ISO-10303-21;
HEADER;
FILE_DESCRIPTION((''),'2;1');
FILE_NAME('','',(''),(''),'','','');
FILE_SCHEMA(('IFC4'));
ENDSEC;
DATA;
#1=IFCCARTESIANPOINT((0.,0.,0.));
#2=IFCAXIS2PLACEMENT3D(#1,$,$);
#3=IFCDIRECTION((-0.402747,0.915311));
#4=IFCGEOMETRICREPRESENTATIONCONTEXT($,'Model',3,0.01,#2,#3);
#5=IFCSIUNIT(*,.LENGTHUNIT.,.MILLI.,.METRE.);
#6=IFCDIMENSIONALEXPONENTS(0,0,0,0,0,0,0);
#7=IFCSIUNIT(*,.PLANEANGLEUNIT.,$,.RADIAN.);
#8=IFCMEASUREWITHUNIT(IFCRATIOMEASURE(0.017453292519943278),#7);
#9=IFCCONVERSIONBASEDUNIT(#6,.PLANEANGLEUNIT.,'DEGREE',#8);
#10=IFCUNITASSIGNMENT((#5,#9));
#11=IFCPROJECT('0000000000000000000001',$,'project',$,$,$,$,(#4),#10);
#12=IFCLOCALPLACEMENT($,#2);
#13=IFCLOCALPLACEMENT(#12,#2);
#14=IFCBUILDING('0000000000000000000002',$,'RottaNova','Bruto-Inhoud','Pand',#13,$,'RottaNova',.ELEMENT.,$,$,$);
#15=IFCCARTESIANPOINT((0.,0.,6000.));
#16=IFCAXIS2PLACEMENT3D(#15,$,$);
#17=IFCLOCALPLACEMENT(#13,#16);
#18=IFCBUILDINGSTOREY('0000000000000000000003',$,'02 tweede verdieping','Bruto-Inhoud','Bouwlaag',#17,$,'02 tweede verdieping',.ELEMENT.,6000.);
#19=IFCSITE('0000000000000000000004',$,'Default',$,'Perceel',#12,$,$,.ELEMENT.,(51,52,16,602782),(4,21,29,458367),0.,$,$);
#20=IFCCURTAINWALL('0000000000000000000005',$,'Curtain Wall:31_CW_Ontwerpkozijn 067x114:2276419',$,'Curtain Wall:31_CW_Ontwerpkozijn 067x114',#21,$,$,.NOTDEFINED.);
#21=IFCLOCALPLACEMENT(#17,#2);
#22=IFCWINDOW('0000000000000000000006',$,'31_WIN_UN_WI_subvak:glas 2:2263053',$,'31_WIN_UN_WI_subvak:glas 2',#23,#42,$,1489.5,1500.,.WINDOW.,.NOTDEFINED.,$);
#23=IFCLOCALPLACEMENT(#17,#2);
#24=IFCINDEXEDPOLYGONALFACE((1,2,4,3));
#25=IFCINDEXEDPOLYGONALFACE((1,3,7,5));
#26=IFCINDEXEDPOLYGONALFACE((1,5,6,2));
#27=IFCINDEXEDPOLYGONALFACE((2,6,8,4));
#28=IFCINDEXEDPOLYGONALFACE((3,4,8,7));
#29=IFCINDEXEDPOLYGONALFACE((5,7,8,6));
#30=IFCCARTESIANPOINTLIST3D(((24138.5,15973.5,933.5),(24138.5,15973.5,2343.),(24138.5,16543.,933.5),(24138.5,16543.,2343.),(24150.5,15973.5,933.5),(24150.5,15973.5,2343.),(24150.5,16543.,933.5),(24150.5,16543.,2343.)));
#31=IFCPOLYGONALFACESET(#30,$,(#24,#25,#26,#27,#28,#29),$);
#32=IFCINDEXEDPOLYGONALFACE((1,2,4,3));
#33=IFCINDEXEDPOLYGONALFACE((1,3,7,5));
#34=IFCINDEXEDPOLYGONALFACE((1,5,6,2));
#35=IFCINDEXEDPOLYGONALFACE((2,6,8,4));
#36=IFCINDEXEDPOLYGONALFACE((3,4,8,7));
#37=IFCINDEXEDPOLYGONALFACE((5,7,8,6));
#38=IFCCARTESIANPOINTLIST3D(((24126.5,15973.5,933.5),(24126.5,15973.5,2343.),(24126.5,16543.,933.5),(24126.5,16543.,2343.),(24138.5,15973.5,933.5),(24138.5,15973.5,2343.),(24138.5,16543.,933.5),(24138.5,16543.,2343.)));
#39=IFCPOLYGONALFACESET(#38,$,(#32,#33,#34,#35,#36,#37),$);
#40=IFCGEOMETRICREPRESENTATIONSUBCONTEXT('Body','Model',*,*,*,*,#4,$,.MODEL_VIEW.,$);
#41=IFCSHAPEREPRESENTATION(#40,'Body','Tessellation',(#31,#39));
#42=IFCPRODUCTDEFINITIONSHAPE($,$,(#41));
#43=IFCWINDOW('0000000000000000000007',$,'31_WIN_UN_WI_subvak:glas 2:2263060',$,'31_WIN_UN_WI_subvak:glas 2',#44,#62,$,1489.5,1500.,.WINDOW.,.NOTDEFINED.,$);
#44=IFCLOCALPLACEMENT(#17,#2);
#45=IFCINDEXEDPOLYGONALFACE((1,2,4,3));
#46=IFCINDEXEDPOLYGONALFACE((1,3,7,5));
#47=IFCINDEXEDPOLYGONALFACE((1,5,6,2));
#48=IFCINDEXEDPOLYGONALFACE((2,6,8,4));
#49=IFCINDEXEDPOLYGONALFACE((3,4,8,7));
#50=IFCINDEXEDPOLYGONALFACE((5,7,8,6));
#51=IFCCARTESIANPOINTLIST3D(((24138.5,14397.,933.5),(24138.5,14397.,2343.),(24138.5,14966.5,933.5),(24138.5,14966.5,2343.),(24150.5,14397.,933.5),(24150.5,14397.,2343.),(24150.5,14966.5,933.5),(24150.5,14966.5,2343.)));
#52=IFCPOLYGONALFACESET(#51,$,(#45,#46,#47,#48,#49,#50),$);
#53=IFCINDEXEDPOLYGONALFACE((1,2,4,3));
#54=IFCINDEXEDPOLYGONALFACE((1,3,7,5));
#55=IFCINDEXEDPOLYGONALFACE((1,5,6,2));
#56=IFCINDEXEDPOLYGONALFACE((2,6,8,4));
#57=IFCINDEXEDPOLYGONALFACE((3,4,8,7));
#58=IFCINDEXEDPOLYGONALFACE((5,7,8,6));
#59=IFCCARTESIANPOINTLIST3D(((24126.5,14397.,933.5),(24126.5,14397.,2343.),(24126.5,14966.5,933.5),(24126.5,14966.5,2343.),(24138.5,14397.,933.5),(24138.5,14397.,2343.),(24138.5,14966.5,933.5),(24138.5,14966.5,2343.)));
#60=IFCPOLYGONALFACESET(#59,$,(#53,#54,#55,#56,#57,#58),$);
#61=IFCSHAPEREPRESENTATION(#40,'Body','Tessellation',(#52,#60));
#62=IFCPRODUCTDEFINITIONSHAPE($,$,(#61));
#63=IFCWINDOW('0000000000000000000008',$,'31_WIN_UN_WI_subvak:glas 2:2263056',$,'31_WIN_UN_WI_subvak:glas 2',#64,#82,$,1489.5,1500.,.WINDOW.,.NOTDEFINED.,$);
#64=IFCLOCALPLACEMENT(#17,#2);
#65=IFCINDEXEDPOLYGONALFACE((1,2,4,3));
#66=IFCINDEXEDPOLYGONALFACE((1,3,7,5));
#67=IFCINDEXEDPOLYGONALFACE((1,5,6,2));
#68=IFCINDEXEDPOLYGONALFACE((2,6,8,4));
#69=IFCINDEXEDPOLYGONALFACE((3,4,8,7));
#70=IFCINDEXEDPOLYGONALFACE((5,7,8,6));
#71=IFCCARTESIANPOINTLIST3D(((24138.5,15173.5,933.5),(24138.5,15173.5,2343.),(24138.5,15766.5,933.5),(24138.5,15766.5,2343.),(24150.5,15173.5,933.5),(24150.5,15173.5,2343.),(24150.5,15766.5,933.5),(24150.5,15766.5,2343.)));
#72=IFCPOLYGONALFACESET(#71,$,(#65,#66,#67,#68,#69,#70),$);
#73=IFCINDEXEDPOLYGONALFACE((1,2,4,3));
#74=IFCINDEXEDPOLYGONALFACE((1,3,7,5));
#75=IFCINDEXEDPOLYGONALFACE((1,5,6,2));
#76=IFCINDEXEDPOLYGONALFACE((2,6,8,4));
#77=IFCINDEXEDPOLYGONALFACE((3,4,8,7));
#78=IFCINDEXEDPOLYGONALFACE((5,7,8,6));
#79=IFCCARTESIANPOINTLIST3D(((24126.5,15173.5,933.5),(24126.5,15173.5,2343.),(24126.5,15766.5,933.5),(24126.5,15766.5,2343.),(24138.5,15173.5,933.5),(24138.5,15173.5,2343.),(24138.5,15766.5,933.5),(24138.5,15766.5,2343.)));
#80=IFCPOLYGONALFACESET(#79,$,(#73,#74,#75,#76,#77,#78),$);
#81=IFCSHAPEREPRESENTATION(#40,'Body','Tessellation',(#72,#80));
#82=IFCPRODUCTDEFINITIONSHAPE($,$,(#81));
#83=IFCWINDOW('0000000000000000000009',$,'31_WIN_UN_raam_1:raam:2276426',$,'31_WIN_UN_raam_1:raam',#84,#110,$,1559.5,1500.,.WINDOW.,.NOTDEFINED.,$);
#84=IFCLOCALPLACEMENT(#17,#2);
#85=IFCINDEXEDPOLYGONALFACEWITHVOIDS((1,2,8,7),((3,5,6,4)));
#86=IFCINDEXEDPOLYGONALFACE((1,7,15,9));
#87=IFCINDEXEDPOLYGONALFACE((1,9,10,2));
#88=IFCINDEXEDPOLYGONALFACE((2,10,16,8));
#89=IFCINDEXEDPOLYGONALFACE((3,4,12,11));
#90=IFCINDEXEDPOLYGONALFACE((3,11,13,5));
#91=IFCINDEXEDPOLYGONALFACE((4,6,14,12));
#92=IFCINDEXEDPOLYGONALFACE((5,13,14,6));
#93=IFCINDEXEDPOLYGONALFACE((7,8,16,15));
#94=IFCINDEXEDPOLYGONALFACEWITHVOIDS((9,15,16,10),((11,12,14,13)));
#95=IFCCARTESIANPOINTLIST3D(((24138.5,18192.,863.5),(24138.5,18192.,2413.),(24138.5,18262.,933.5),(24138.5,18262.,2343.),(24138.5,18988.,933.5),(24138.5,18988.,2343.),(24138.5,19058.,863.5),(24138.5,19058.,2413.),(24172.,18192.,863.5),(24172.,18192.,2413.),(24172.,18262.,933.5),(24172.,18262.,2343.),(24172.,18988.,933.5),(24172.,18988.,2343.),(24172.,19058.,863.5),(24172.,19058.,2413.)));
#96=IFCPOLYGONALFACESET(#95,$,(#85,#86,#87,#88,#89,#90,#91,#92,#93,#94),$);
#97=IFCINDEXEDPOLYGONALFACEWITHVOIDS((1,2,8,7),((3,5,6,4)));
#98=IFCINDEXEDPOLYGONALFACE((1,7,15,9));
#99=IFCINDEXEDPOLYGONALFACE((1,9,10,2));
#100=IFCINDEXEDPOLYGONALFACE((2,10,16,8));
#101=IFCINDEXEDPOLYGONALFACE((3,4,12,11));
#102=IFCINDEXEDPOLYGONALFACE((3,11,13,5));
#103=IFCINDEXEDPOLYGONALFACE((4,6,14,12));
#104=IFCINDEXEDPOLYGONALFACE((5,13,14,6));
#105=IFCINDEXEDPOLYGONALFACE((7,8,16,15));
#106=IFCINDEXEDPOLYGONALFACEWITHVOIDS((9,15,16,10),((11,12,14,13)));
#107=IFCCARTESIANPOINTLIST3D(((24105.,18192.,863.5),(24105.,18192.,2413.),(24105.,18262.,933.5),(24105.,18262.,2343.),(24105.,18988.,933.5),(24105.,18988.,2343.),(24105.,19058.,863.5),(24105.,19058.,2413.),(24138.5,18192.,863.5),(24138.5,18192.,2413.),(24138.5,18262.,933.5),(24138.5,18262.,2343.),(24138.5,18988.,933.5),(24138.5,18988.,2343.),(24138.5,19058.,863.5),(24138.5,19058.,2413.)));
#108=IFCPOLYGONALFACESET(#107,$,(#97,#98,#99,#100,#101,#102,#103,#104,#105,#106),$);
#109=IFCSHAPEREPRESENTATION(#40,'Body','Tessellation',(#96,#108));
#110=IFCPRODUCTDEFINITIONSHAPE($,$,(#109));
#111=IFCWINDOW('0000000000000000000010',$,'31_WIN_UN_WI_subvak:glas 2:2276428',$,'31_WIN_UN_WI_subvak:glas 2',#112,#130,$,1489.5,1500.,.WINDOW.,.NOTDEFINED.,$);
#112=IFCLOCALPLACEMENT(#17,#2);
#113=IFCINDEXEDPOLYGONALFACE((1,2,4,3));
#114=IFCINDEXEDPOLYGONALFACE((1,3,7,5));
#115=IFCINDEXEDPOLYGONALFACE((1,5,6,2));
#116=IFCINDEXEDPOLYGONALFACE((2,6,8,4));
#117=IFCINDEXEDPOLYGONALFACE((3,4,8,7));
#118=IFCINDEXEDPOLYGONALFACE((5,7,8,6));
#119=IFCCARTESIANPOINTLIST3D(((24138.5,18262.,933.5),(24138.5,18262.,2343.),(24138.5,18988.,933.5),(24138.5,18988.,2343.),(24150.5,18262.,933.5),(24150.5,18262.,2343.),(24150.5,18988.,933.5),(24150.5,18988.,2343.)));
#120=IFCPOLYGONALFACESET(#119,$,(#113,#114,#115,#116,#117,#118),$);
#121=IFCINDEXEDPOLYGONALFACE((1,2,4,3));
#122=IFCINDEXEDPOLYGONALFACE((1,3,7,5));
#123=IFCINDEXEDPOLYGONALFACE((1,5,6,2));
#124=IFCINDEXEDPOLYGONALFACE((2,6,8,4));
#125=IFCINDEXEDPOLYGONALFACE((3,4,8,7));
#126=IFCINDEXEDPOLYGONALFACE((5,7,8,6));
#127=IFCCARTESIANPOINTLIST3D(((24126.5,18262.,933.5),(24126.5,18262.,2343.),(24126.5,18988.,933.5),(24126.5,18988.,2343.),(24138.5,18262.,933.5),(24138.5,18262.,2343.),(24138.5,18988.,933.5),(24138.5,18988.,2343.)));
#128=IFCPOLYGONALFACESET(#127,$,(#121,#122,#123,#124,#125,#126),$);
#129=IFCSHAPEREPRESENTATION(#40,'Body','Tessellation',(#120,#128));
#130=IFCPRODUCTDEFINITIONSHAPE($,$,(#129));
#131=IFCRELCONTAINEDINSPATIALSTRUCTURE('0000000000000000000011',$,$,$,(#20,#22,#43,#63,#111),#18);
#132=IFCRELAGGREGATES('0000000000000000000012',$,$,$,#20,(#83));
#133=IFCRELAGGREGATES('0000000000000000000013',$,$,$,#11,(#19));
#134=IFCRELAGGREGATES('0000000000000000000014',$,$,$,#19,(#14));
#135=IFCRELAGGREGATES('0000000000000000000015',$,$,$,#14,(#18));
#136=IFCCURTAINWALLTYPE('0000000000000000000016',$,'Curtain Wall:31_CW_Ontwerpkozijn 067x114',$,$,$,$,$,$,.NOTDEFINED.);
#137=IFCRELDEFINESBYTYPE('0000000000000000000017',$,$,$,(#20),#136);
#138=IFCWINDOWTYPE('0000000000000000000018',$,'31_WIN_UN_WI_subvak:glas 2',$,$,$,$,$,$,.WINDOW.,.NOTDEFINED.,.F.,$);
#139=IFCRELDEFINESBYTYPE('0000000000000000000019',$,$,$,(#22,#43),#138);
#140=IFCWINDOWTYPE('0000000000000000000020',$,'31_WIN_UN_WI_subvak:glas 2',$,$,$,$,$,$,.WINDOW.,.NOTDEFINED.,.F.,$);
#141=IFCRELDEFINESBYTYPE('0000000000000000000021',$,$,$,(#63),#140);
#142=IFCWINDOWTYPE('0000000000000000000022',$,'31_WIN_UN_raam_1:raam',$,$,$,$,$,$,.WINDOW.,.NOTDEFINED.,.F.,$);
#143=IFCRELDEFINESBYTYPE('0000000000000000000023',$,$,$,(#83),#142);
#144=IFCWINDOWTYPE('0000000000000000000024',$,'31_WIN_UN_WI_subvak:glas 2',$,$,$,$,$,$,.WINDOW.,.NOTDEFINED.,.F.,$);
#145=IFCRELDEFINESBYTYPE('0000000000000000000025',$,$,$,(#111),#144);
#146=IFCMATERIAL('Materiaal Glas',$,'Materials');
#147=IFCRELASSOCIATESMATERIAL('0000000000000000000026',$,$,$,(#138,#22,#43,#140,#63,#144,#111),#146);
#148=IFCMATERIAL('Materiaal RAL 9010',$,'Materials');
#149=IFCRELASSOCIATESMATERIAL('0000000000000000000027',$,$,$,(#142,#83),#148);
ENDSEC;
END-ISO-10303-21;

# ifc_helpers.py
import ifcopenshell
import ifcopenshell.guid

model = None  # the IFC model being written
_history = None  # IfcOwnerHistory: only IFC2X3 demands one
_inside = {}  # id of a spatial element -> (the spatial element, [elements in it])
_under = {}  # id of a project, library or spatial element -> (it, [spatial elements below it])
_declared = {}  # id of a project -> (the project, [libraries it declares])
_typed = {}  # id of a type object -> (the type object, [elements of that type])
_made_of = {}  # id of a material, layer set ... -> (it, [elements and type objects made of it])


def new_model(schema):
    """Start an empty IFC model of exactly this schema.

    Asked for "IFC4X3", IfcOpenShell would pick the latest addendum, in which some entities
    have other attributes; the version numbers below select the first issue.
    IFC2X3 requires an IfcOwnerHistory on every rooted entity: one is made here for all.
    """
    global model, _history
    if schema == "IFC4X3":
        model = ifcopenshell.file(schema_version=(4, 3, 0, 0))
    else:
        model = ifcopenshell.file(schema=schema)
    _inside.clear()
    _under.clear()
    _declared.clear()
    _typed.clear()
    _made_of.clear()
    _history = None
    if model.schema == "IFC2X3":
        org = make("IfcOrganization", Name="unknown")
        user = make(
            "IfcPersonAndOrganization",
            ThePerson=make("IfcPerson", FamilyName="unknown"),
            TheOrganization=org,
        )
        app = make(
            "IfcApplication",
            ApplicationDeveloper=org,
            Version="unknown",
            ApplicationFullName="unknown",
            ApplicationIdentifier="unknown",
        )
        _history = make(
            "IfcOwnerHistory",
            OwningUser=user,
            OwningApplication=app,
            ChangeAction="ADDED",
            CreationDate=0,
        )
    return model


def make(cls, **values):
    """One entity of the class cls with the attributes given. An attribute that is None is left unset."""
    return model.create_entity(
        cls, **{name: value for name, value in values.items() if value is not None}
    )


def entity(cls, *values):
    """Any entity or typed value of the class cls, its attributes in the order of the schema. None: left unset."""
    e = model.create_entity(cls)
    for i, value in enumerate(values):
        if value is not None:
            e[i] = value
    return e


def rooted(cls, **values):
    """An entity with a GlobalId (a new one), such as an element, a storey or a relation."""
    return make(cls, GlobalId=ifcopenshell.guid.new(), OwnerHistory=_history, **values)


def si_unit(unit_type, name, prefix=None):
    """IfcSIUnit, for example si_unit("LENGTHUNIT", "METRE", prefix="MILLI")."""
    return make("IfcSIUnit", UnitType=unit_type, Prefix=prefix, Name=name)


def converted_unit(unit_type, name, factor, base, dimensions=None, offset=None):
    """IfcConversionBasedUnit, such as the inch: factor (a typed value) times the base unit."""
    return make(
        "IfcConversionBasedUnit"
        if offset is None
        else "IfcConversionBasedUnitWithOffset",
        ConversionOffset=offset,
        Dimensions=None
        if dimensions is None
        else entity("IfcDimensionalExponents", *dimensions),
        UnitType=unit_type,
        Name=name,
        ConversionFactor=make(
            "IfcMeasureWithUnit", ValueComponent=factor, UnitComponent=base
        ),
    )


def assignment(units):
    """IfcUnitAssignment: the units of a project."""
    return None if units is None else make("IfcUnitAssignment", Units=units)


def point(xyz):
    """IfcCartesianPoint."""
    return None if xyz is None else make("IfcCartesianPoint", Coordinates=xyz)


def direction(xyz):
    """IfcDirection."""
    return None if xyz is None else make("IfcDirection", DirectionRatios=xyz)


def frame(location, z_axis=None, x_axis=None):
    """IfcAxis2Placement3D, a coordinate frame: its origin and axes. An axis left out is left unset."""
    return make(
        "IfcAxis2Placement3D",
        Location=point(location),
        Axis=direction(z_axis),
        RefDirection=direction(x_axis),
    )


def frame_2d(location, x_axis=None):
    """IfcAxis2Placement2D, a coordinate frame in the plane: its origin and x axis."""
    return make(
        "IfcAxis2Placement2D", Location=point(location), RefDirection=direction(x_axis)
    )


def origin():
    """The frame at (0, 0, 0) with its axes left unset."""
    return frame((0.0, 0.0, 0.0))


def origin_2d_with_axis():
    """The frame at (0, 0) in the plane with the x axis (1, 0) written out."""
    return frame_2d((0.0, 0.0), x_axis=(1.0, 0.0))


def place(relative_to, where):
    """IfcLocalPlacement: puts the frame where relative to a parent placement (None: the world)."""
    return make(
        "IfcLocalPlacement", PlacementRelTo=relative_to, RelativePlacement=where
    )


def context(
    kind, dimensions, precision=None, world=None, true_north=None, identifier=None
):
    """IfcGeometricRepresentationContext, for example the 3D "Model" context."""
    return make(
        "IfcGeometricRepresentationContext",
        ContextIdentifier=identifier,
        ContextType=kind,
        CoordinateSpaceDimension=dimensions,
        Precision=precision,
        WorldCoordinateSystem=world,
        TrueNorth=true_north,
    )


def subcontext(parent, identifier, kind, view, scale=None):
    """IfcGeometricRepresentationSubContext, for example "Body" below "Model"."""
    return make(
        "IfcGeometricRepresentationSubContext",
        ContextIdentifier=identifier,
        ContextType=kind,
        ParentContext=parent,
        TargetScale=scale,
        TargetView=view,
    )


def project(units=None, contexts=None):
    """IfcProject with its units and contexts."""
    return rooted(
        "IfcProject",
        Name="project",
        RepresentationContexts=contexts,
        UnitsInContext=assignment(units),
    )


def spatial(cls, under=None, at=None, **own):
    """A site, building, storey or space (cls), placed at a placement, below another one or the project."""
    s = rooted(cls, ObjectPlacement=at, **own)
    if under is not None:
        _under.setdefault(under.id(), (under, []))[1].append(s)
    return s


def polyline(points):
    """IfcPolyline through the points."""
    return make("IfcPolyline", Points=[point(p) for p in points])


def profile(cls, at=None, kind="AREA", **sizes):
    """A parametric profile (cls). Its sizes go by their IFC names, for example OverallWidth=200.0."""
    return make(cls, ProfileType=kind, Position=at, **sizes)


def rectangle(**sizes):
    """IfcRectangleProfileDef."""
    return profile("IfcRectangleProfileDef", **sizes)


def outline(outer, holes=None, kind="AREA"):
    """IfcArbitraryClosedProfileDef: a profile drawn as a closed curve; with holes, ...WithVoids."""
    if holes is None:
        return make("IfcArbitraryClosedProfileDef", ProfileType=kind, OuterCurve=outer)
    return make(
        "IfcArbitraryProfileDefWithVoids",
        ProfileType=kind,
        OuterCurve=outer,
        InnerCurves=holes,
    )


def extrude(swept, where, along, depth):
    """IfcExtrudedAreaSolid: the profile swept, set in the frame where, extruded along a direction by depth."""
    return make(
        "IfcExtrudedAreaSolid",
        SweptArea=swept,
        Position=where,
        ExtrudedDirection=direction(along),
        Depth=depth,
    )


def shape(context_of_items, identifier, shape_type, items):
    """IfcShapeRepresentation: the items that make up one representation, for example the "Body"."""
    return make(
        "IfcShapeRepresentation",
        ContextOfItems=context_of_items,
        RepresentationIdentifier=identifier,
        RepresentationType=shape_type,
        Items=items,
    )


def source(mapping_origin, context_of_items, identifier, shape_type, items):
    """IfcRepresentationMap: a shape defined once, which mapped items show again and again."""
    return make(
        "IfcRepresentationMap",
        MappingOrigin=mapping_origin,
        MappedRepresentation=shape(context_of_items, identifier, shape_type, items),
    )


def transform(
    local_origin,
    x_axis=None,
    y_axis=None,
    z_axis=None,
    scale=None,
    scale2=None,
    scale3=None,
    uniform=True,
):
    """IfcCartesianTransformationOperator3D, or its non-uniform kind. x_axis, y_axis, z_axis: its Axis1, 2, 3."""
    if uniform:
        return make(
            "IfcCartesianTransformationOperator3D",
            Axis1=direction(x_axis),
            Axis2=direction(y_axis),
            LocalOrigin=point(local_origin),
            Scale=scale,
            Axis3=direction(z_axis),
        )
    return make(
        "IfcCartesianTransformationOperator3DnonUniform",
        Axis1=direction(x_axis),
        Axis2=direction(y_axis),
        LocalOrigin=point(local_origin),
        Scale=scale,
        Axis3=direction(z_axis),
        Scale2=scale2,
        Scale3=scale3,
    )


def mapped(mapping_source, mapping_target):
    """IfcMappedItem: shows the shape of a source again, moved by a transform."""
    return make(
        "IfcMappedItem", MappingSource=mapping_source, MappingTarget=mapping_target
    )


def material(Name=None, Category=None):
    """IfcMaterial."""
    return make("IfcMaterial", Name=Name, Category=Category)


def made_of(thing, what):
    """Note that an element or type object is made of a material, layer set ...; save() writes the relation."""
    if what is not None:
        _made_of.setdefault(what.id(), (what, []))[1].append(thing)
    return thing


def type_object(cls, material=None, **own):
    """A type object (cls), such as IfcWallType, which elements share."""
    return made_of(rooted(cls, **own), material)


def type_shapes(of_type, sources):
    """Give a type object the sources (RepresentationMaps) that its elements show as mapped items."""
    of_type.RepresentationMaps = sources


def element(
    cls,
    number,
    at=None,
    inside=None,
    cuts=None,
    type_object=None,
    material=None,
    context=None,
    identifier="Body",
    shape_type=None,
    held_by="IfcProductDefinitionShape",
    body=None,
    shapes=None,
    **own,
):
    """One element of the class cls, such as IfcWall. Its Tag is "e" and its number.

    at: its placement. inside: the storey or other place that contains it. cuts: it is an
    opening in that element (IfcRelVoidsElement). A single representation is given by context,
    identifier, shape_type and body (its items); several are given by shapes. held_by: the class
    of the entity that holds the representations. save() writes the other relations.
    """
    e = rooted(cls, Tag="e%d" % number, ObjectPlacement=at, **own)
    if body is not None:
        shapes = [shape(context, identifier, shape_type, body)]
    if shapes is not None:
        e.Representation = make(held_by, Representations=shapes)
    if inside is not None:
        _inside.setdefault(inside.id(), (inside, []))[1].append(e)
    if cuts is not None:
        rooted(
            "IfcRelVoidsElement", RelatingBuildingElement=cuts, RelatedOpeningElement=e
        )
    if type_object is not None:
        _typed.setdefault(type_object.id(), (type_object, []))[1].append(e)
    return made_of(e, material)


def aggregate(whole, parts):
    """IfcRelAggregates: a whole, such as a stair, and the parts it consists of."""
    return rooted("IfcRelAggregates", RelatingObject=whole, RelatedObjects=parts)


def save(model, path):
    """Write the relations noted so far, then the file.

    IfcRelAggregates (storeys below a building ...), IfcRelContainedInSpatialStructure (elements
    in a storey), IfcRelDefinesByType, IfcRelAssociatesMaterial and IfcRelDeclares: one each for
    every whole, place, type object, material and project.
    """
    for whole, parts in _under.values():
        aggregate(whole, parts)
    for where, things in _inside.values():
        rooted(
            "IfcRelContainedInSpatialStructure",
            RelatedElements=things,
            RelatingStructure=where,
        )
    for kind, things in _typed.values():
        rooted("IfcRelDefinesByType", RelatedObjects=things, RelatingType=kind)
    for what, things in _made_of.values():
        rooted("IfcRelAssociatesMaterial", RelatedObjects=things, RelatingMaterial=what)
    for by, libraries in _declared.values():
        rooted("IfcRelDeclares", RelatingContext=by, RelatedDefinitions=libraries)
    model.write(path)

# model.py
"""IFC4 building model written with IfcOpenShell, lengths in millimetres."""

from ifc_helpers import new_model, entity, si_unit, converted_unit, direction, frame, frame_2d, origin, origin_2d_with_axis, place, context, subcontext, project, spatial, polyline, rectangle, outline, extrude, source, transform, mapped, material, type_object, type_shapes, element, aggregate, save


model = new_model("IFC4")

# Units and contexts
model_context = context("Model", 3, precision=0.01, world=origin(), true_north=direction((-0.402747, 0.915311)))
body_context = subcontext(model_context, "Body", "Model", "MODEL_VIEW")
ifc_project = project(units=[si_unit("LENGTHUNIT", "METRE", prefix="MILLI"), converted_unit("PLANEANGLEUNIT", "DEGREE", entity("IfcRatioMeasure", 0.017453292519943278), si_unit("PLANEANGLEUNIT", "RADIAN"), dimensions=[0, 0, 0, 0, 0, 0, 0])], contexts=[model_context])

# Site, building, storey
site_placement = place(None, origin())
site = spatial("IfcSite", under=ifc_project, at=site_placement, Name="Default", ObjectType="Perceel", CompositionType="ELEMENT", RefLatitude=(51, 52, 16, 602782), RefLongitude=(4, 21, 29, 458367), RefElevation=0.0)
building_placement = place(site_placement, origin())
building = spatial("IfcBuilding", under=site, at=building_placement, Name="RottaNova", Description="Bruto-Inhoud", ObjectType="Pand", LongName="RottaNova", CompositionType="ELEMENT")
storey_placement = place(building_placement, frame((0.0, 0.0, 6000.0)))
storey = spatial("IfcBuildingStorey", under=building, at=storey_placement, Name="02 tweede verdieping", Description="Bruto-Inhoud", ObjectType="Bouwlaag", LongName="02 tweede verdieping", CompositionType="ELEMENT", Elevation=6000.0)

# Curtain wall
curtain_wall_type = type_object("IfcCurtainWallType", Name="Curtain Wall:31_CW_Ontwerpkozijn 067x114", PredefinedType="NOTDEFINED")
curtain_wall_1_placement = place(storey_placement, frame((0.0, 0.0, -6000.0)))
curtain_wall_1 = element("IfcCurtainWall", 1, at=curtain_wall_1_placement, inside=storey, type_object=curtain_wall_type, Name="Curtain Wall:31_CW_Ontwerpkozijn 067x114:2276419", ObjectType="Curtain Wall:31_CW_Ontwerpkozijn 067x114", PredefinedType="NOTDEFINED")

# Shared definitions
ifc_material_1 = material(Name="Materiaal Glas", Category="Materials")

# Windows
window_type_1 = type_object("IfcWindowType", Name="31_WIN_UN_WI_subvak:glas 2", ParameterTakesPrecedence=False, PartitioningType="NOTDEFINED", PredefinedType="WINDOW", material=ifc_material_1)
shared_shape_1 = source(origin(), body_context, "Body", "SweptSolid", [
    extrude(rectangle(XDim=12.0, YDim=569.5, at=origin_2d_with_axis()), frame((0.0, 6.0, 0.0), z_axis=(0.0, 0.0, 1.0), x_axis=(0.0, -1.0, 0.0)), (0.0, 0.0, 1.0), 1409.5),
    extrude(rectangle(XDim=12.0, YDim=569.5, at=frame_2d((0.0, 0.0), x_axis=(1.0, 0.0))), frame((0.0, -6.0, 0.0), z_axis=(0.0, 0.0, 1.0), x_axis=(0.0, -1.0, 0.0)), (0.0, 0.0, 1.0), 1409.5),
])
type_shapes(window_type_1, [shared_shape_1])
for number, where, z_axis, x_axis, name in (
    (2, (24138.5, 16258.3, 933.5), (0.0, 0.0, 1.0), (0.0, -1.0, 0.0), "31_WIN_UN_WI_subvak:glas 2:2263053"),
    (3, (24138.5, 14681.8, 933.5), (0.0, 0.0, 1.0), (0.0, -1.0, 0.0), "31_WIN_UN_WI_subvak:glas 2:2263060"),
):
    element("IfcWindow", number, at=place(storey_placement, frame(where, z_axis=z_axis, x_axis=x_axis)), inside=storey, type_object=window_type_1, material=ifc_material_1, Name=name, ObjectType="31_WIN_UN_WI_subvak:glas 2", OverallHeight=1489.5, OverallWidth=1500.0, PartitioningType="NOTDEFINED", PredefinedType="WINDOW", context=body_context, shape_type="MappedRepresentation", body=[
        mapped(shared_shape_1, transform((0.0, 0.0, 0.0), scale=1.0)),
    ])
window_type_2 = type_object("IfcWindowType", Name="31_WIN_UN_WI_subvak:glas 2", ParameterTakesPrecedence=False, PartitioningType="NOTDEFINED", PredefinedType="WINDOW", material=ifc_material_1)
shared_shape_2 = source(origin(), body_context, "Body", "SweptSolid", [
    extrude(rectangle(XDim=12.0, YDim=593.0, at=frame_2d((0.0, 0.0), x_axis=(1.0, 0.0))), frame((0.0, 6.0, 0.0), z_axis=(0.0, 0.0, 1.0), x_axis=(0.0, -1.0, 0.0)), (0.0, 0.0, 1.0), 1409.5),
    extrude(rectangle(XDim=12.0, YDim=593.0, at=frame_2d((0.0, 0.0), x_axis=(1.0, 0.0))), frame((0.0, -6.0, 0.0), z_axis=(0.0, 0.0, 1.0), x_axis=(0.0, -1.0, 0.0)), (0.0, 0.0, 1.0), 1409.5),
])
type_shapes(window_type_2, [shared_shape_2])
window_1_placement = place(storey_placement, frame((24138.5, 15470.0, 933.5), z_axis=(0.0, 0.0, 1.0), x_axis=(0.0, -1.0, 0.0)))
element("IfcWindow", 4, at=window_1_placement, inside=storey, type_object=window_type_2, material=ifc_material_1, Name="31_WIN_UN_WI_subvak:glas 2:2263056", ObjectType="31_WIN_UN_WI_subvak:glas 2", OverallHeight=1489.5, OverallWidth=1500.0, PartitioningType="NOTDEFINED", PredefinedType="WINDOW", context=body_context, shape_type="MappedRepresentation", body=[
    mapped(shared_shape_2, transform((0.0, 0.0, 0.0), scale=1.0)),
])

# Windows
ifc_material_2 = material(Name="Materiaal RAL 9010", Category="Materials")
window_type_3 = type_object("IfcWindowType", Name="31_WIN_UN_raam_1:raam", ParameterTakesPrecedence=False, PartitioningType="NOTDEFINED", PredefinedType="WINDOW", material=ifc_material_2)
shared_shape_3 = source(origin(), body_context, "Body", "SweptSolid", [
    extrude(outline(polyline([(-433.0, -774.7), (433.0, -774.7), (433.0, 774.7), (-433.0, 774.7), (-433.0, -774.7)]), holes=[polyline([(-363.0, 704.7), (363.0, 704.7), (363.0, -704.8), (-363.0, -704.8), (-363.0, 704.7)])]), frame((0.0, 92.0, 774.8), z_axis=(0.0, -1.0, 0.0), x_axis=(-1.0, 0.0, 0.0)), (0.0, 0.0, 1.0), 33.5),
    extrude(outline(polyline([(-433.0, -774.7), (433.0, -774.7), (433.0, 774.7), (-433.0, 774.7), (-433.0, -774.7)]), holes=[polyline([(-363.0, 704.7), (363.0, 704.7), (363.0, -704.8), (-363.0, -704.8), (-363.0, 704.7)])]), frame((0.0, 58.5, 774.8), z_axis=(0.0, -1.0, 0.0), x_axis=(-1.0, 0.0, 0.0)), (0.0, 0.0, 1.0), 33.5),
])
type_shapes(window_type_3, [shared_shape_3])
window_2_placement = place(curtain_wall_1_placement, frame((24080.0, 18625.0, 6863.5), z_axis=(0.0, 0.0, 1.0), x_axis=(0.0, -1.0, 0.0)))
window_2 = element("IfcWindow", 5, at=window_2_placement, type_object=window_type_3, material=ifc_material_2, Name="31_WIN_UN_raam_1:raam:2276426", ObjectType="31_WIN_UN_raam_1:raam", OverallHeight=1559.5, OverallWidth=1500.0, PartitioningType="NOTDEFINED", PredefinedType="WINDOW", context=body_context, shape_type="MappedRepresentation", body=[
    mapped(shared_shape_3, transform((0.0, 0.0, 0.0), scale=1.0)),
])
aggregate(curtain_wall_1, [window_2])
window_type_4 = type_object("IfcWindowType", Name="31_WIN_UN_WI_subvak:glas 2", ParameterTakesPrecedence=False, PartitioningType="NOTDEFINED", PredefinedType="WINDOW", material=ifc_material_1)
shared_shape_4 = source(origin(), body_context, "Body", "SweptSolid", [
    extrude(rectangle(XDim=726.0, YDim=12.0, at=origin_2d_with_axis()), frame((0.0, -6.0, 0.0)), (0.0, 0.0, 1.0), 1409.5),
    extrude(rectangle(XDim=726.0, YDim=12.0, at=origin_2d_with_axis()), frame((0.0, 6.0, 0.0)), (0.0, 0.0, 1.0), 1409.5),
])
type_shapes(window_type_4, [shared_shape_4])
window_3_placement = place(storey_placement, frame((24138.5, 18625.0, 933.5), z_axis=(0.0, 0.0, 1.0), x_axis=(0.0, 1.0, 0.0)))
element("IfcWindow", 6, at=window_3_placement, inside=storey, type_object=window_type_4, material=ifc_material_1, Name="31_WIN_UN_WI_subvak:glas 2:2276428", ObjectType="31_WIN_UN_WI_subvak:glas 2", OverallHeight=1489.5, OverallWidth=1500.0, PartitioningType="NOTDEFINED", PredefinedType="WINDOW", context=body_context, shape_type="MappedRepresentation", body=[
    mapped(shared_shape_4, transform((0.0, 0.0, 0.0), scale=1.0)),
])

save(model, "model.ifc")
